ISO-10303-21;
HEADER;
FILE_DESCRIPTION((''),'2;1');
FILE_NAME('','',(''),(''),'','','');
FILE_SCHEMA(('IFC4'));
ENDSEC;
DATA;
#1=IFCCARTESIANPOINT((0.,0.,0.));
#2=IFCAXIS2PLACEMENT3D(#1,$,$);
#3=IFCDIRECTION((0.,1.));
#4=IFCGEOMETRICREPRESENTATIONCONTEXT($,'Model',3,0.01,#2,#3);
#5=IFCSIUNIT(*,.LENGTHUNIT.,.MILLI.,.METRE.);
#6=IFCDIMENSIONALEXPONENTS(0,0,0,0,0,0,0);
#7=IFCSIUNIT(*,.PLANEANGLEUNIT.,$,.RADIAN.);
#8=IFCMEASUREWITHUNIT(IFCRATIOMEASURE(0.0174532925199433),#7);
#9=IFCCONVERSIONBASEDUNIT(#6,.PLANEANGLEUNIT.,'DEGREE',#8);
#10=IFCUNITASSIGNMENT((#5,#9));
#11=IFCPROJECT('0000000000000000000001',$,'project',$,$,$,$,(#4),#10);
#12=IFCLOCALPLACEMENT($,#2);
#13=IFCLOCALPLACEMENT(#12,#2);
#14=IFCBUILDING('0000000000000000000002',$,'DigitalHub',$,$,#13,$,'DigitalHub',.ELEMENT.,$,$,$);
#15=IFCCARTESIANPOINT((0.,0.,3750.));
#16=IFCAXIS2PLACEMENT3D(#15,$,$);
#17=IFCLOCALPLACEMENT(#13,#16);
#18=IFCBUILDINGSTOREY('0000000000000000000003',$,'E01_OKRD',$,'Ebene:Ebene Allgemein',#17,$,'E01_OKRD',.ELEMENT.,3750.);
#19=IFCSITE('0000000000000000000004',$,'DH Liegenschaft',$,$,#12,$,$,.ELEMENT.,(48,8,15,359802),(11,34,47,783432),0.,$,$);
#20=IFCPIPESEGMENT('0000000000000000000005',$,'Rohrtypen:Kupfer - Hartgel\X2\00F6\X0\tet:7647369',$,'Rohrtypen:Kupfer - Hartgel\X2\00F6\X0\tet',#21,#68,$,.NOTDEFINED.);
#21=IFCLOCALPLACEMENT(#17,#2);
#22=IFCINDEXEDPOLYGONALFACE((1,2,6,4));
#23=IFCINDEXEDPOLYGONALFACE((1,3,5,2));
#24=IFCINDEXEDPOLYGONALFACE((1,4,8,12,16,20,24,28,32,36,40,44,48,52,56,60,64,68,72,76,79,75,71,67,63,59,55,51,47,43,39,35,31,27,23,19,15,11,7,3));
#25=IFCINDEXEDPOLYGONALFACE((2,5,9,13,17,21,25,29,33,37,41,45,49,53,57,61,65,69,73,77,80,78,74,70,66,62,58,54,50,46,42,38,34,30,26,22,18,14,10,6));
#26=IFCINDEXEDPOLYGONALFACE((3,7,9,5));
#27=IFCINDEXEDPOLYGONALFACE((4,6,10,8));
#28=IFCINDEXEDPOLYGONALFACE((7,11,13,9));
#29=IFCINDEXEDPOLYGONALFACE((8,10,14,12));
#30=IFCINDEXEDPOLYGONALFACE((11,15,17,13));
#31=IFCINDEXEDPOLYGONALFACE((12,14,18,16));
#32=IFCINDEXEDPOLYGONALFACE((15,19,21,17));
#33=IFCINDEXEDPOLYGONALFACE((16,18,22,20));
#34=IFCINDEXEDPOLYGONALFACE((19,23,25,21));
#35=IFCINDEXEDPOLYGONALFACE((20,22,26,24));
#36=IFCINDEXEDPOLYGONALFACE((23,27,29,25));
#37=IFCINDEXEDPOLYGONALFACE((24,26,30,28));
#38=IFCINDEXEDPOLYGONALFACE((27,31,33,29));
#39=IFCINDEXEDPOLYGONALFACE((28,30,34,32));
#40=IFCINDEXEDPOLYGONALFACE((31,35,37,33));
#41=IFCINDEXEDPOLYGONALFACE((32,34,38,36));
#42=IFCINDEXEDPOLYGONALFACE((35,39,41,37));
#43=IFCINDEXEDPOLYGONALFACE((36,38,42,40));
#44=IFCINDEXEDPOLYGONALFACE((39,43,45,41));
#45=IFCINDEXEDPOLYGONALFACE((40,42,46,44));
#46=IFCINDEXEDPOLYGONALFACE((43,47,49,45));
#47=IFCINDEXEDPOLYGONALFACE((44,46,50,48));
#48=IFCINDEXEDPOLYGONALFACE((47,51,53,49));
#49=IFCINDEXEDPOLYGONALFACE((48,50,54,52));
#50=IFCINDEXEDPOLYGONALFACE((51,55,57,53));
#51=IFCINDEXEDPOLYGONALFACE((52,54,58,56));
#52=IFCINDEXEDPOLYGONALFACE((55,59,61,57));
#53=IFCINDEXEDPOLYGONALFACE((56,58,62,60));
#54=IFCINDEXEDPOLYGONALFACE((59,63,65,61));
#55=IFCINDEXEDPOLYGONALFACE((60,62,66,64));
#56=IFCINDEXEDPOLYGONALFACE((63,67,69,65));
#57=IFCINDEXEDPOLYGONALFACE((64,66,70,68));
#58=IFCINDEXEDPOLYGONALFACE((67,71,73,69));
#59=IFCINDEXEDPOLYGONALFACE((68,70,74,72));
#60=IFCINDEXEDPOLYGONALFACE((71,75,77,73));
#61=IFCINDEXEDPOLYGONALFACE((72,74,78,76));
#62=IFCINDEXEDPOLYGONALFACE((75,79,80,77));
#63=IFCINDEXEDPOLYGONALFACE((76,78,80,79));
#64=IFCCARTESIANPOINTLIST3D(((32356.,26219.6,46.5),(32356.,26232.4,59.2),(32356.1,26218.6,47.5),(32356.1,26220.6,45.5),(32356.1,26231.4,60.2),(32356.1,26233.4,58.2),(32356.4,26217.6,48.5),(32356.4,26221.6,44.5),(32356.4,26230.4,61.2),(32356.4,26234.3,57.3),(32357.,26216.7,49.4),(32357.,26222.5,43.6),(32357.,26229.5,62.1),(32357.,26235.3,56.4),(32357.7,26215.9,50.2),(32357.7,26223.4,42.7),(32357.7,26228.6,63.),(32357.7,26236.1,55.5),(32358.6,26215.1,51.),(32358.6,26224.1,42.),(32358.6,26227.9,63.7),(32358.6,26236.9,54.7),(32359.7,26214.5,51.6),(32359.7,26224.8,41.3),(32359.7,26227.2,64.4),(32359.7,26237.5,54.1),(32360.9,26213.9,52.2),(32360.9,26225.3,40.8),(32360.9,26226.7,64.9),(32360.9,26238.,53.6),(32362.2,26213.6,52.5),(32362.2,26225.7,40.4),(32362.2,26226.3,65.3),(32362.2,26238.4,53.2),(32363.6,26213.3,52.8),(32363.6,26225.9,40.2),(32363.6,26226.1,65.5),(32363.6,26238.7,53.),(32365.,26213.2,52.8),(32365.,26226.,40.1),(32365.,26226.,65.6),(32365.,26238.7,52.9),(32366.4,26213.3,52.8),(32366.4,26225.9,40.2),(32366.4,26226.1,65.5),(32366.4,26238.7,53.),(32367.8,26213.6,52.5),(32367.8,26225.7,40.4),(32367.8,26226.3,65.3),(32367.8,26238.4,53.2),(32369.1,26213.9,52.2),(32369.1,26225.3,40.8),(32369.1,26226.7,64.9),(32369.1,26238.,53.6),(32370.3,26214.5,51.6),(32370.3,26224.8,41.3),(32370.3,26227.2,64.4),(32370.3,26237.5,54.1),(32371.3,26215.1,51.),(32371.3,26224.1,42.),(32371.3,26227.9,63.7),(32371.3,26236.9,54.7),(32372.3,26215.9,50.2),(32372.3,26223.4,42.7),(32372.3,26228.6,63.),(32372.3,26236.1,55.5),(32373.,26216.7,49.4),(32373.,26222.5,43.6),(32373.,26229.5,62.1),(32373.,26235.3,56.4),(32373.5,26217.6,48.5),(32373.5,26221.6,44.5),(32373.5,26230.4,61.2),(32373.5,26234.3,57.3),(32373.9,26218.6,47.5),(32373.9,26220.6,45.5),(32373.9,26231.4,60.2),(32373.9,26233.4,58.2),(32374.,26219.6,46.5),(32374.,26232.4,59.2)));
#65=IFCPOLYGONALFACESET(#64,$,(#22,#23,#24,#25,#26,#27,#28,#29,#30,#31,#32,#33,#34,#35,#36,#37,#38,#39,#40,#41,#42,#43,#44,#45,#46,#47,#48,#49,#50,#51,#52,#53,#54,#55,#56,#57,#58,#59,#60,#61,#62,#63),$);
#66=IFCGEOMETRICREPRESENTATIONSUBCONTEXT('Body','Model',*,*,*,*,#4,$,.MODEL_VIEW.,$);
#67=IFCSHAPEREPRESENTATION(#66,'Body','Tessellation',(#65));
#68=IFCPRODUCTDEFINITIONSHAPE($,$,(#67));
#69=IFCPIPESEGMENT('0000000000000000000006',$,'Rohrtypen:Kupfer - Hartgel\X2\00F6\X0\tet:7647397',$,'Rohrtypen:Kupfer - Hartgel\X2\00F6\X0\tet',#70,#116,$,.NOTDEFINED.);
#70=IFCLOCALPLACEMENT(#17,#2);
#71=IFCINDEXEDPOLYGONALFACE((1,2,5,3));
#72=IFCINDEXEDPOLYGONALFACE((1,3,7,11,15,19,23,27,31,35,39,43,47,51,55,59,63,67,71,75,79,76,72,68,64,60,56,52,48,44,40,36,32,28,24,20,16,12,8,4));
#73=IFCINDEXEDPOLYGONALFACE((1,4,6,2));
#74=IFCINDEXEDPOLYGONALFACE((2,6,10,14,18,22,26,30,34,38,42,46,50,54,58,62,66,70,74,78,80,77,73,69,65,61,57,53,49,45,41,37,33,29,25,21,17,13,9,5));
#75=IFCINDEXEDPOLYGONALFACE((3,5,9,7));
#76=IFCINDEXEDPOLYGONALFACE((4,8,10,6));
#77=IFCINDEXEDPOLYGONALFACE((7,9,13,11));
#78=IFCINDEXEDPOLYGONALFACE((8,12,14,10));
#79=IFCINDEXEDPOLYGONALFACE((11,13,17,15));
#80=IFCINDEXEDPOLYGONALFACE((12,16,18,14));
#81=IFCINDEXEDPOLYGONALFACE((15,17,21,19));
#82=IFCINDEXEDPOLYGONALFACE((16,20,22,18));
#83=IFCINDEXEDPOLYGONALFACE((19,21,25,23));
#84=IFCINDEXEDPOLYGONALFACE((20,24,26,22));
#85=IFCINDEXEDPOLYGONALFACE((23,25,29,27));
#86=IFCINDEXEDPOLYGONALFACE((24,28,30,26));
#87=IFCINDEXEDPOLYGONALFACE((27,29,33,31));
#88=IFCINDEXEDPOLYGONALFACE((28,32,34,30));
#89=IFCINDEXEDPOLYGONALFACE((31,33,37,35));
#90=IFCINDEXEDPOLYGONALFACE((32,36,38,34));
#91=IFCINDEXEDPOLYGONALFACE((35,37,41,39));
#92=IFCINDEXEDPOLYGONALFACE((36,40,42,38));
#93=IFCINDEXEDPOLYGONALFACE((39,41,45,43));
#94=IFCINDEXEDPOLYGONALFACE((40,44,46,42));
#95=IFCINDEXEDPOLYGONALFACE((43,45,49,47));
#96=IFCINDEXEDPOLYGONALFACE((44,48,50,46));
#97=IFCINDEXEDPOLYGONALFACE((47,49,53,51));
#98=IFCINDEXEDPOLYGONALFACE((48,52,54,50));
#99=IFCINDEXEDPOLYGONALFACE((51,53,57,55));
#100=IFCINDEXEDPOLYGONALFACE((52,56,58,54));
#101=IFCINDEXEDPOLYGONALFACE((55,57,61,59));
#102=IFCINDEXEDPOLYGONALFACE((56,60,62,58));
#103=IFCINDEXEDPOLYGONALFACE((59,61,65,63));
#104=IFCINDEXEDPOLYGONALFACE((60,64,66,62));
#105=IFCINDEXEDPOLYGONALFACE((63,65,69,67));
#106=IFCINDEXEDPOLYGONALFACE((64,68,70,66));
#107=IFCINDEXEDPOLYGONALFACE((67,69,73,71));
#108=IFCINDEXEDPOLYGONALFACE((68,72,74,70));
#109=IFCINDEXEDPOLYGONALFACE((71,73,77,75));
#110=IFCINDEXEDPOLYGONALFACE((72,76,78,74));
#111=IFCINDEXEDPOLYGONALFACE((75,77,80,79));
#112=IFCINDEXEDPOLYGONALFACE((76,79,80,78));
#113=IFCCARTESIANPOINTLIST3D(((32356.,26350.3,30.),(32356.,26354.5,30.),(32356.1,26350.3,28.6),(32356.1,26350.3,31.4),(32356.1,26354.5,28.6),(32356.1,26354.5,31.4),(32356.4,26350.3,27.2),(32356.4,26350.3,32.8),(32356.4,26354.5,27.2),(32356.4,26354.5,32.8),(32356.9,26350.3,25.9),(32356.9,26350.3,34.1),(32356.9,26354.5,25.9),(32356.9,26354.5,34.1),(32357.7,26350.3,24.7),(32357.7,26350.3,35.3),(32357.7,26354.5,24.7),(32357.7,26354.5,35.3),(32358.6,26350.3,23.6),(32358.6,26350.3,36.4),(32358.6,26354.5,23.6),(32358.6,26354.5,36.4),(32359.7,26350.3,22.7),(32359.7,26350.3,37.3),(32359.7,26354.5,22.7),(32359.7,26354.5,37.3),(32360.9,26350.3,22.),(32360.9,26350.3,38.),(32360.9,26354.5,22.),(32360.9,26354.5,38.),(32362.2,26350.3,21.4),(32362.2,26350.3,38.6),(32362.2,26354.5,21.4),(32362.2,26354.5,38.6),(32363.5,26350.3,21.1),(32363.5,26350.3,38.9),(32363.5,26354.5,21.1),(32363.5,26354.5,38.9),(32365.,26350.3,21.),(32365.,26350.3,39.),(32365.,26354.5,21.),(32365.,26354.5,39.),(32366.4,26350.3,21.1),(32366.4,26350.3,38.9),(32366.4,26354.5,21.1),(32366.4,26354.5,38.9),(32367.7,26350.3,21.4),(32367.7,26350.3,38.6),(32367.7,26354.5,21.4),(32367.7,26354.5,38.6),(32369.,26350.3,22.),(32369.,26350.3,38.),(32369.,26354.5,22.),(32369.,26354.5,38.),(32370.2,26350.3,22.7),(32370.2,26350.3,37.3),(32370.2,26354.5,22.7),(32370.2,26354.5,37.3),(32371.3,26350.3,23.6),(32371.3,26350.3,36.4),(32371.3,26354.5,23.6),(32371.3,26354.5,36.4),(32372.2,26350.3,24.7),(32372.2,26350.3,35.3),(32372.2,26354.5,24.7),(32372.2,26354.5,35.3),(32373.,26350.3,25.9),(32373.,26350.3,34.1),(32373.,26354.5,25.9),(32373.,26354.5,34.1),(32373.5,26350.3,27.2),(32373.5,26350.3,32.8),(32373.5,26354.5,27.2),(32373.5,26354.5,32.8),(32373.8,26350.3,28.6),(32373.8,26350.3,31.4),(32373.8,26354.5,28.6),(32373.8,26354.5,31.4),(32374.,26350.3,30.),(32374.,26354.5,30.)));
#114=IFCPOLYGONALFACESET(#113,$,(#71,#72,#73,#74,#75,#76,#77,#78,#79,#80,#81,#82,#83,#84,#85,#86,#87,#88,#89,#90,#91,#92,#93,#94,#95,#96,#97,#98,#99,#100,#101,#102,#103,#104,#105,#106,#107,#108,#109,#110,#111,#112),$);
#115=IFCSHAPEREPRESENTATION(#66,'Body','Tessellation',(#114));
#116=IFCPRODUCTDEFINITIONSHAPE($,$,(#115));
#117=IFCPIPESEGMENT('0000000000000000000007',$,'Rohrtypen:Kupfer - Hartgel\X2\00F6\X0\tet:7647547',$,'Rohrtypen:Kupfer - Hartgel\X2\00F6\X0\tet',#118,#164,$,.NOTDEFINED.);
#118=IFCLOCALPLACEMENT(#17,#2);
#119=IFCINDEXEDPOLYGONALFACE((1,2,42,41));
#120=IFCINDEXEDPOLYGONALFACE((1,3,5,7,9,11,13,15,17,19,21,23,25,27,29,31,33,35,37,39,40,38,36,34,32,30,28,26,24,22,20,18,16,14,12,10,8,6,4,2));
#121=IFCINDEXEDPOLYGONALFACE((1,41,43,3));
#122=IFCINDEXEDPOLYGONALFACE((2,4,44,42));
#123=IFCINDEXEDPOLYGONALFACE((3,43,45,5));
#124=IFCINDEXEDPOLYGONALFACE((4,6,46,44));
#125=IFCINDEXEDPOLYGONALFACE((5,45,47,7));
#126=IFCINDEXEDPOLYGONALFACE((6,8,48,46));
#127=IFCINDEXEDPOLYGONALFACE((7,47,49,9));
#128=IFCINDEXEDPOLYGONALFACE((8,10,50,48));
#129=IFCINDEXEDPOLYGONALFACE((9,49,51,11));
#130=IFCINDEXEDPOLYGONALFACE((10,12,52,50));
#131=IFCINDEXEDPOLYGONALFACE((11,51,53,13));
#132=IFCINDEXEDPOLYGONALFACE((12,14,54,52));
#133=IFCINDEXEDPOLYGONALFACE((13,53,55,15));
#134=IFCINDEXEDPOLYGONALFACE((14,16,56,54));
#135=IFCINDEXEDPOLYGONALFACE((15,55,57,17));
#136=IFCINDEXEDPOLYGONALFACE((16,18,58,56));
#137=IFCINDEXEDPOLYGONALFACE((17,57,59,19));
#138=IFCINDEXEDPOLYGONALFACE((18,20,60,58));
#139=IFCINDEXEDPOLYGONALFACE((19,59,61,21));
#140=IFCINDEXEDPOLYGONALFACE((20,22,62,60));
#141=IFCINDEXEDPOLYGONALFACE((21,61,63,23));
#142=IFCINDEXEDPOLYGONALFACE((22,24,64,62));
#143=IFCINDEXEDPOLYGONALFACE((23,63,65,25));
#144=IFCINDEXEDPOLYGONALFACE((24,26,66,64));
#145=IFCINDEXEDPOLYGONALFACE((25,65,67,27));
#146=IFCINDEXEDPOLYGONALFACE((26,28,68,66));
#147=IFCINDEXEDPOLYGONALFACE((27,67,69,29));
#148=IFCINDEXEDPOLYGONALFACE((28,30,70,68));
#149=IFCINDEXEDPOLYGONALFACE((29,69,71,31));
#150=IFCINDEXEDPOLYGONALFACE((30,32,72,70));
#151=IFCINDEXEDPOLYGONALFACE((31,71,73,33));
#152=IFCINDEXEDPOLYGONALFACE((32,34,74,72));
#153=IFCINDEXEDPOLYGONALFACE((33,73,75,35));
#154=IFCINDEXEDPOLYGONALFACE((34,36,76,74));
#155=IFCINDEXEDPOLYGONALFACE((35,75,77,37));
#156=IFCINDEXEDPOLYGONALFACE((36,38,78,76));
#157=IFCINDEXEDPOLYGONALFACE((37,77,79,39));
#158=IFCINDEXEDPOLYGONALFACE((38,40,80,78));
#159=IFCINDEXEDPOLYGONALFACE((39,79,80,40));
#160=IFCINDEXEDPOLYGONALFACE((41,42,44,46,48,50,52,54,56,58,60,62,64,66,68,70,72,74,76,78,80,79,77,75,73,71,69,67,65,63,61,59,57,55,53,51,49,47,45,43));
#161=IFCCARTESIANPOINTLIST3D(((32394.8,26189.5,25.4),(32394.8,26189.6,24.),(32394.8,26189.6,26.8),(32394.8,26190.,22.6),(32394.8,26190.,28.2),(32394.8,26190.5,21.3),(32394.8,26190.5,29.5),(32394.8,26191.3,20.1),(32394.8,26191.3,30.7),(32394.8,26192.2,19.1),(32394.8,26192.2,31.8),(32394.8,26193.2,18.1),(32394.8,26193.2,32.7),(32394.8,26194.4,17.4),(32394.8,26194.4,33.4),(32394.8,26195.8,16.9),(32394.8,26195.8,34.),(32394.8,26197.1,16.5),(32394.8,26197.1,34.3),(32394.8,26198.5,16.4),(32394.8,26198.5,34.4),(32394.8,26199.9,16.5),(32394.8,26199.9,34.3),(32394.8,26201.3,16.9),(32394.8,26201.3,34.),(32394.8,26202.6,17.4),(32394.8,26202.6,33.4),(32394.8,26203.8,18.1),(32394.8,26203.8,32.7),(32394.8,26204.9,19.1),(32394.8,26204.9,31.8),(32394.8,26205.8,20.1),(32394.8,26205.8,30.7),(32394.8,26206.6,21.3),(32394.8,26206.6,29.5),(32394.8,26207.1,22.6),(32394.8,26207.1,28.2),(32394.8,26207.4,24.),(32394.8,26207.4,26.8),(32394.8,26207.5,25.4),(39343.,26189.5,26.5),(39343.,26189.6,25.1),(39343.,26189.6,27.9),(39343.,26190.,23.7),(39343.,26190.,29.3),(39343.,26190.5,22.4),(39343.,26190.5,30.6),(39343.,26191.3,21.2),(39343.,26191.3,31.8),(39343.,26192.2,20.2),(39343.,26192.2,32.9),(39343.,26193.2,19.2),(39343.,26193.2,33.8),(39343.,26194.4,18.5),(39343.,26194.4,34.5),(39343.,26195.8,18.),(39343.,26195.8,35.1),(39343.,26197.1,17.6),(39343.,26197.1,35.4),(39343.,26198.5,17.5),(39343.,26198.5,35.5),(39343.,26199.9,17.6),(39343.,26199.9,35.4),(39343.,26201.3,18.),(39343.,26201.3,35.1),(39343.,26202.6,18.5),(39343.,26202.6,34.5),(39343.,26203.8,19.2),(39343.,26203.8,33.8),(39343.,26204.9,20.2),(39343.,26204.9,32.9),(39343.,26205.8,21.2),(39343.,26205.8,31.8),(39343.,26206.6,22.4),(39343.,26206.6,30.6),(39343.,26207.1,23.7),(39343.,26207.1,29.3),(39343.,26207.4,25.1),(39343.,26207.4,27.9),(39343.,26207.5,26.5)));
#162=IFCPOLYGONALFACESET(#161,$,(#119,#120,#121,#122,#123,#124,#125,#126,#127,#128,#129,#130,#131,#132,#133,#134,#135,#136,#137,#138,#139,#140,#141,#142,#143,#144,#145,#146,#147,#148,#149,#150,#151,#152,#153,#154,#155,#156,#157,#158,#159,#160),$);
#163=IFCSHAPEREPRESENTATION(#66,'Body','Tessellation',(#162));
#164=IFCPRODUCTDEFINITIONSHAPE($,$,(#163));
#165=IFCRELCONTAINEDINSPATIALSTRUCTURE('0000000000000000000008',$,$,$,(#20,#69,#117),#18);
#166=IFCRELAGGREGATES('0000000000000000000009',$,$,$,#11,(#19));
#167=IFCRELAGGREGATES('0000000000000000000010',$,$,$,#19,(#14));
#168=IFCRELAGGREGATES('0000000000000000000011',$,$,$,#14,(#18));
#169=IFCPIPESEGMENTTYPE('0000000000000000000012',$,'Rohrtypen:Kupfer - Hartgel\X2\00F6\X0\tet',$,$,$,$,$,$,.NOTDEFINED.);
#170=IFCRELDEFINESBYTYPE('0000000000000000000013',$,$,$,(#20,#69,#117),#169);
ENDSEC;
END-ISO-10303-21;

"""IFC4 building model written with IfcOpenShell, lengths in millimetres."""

from ifc_helpers import new_model, entity, si_unit, converted_unit, direction, frame, origin, place, context, subcontext, project, spatial, indexed_curve, outline, extrude, type_object, element, save


model = new_model("IFC4")

# Units and contexts
model_context = context("Model", 3, precision=0.01, world=origin(), true_north=direction((0.0, 1.0)))
body_context = subcontext(model_context, "Body", "Model", "MODEL_VIEW")
ifc_project = project(units=[si_unit("LENGTHUNIT", "METRE", prefix="MILLI"), converted_unit("PLANEANGLEUNIT", "DEGREE", entity("IfcRatioMeasure", 0.0174532925199433), si_unit("PLANEANGLEUNIT", "RADIAN"), dimensions=[0, 0, 0, 0, 0, 0, 0])], contexts=[model_context])

# Site, building, storey
site_placement = place(None, origin())
site = spatial("IfcSite", under=ifc_project, at=site_placement, Name="DH Liegenschaft", CompositionType="ELEMENT", RefLatitude=(48, 8, 15, 359802), RefLongitude=(11, 34, 47, 783432), RefElevation=0.0)
building_placement = place(site_placement, origin())
building = spatial("IfcBuilding", under=site, at=building_placement, Name="DigitalHub", LongName="DigitalHub", CompositionType="ELEMENT")
storey_placement = place(building_placement, frame((0.0, 0.0, 3750.0)))
storey = spatial("IfcBuildingStorey", under=building, at=storey_placement, Name="E01_OKRD", ObjectType="Ebene:Ebene Allgemein", LongName="E01_OKRD", CompositionType="ELEMENT", Elevation=3750.0)

# Pipe segments
pipe_segment_type = type_object("IfcPipeSegmentType", Name="Rohrtypen:Kupfer - Hartgelötet", PredefinedType="NOTDEFINED")
pipe_segment_1_placement = place(storey_placement, frame((32354.4, 26211.7, 38.5)))
element("IfcPipeSegment", 1, at=pipe_segment_1_placement, inside=storey, type_object=pipe_segment_type, Name="Rohrtypen:Kupfer - Hartgelötet:7647369", ObjectType="Rohrtypen:Kupfer - Hartgelötet", PredefinedType="NOTDEFINED", context=body_context, shape_type="SweptSolid", body=[
    extrude(outline(indexed_curve([(9.0, 0.0), (8.9, 1.4), (8.6, 2.8), (8.0, 4.1), (7.3, 5.3), (6.4, 6.4), (5.3, 7.3), (4.1, 8.0), (2.8, 8.6), (1.4, 8.9), (0.0, 9.0), (-1.4, 8.9), (-2.8, 8.6), (-4.1, 8.0), (-5.3, 7.3), (-6.4, 6.4), (-7.3, 5.3), (-8.0, 4.1), (-8.6, 2.8), (-8.9, 1.4), (-9.0, 0.0), (-8.9, -1.4), (-8.6, -2.8), (-8.0, -4.1), (-7.3, -5.3), (-6.4, -6.4), (-5.3, -7.3), (-4.1, -8.0), (-2.8, -8.6), (-1.4, -8.9), (0.0, -9.0), (1.4, -8.9), (2.8, -8.6), (4.1, -8.0), (5.3, -7.3), (6.4, -6.4), (7.3, -5.3), (8.0, -4.1), (8.6, -2.8), (8.9, -1.4), (9.0, 0.0)], self_intersect=False)), frame((10.6, 8.0, 8.0), z_axis=(0.0, 0.707107, 0.707107), x_axis=(-1.0, 0.0, 0.0)), (0.0, 0.0, 1.0), 18.0),
])
pipe_segment_2_placement = place(storey_placement, frame((32354.4, 26350.3, 19.4)))
element("IfcPipeSegment", 2, at=pipe_segment_2_placement, inside=storey, type_object=pipe_segment_type, Name="Rohrtypen:Kupfer - Hartgelötet:7647397", ObjectType="Rohrtypen:Kupfer - Hartgelötet", PredefinedType="NOTDEFINED", context=body_context, shape_type="SweptSolid", body=[
    extrude(outline(indexed_curve([(9.0, 0.0), (8.9, 1.4), (8.6, 2.8), (8.0, 4.1), (7.3, 5.3), (6.4, 6.4), (5.3, 7.3), (4.1, 8.0), (2.8, 8.6), (1.4, 8.9), (0.0, 9.0), (-1.4, 8.9), (-2.8, 8.6), (-4.1, 8.0), (-5.3, 7.3), (-6.4, 6.4), (-7.3, 5.3), (-8.0, 4.1), (-8.6, 2.8), (-8.9, 1.4), (-9.0, 0.0), (-8.9, -1.4), (-8.6, -2.8), (-8.0, -4.1), (-7.3, -5.3), (-6.4, -6.4), (-5.3, -7.3), (-4.1, -8.0), (-2.8, -8.6), (-1.4, -8.9), (0.0, -9.0), (1.4, -8.9), (2.8, -8.6), (4.1, -8.0), (5.3, -7.3), (6.4, -6.4), (7.3, -5.3), (8.0, -4.1), (8.6, -2.8), (8.9, -1.4), (9.0, 0.0)], self_intersect=False)), frame((10.6, 0.0, 10.6), z_axis=(0.0, 1.0, 0.0), x_axis=(1.0, 0.0, 0.0)), (0.0, 0.0, 1.0), 4.2),
])
pipe_segment_3_placement = place(storey_placement, frame((32394.8, 26187.9, 14.8)))
element("IfcPipeSegment", 3, at=pipe_segment_3_placement, inside=storey, type_object=pipe_segment_type, Name="Rohrtypen:Kupfer - Hartgelötet:7647547", ObjectType="Rohrtypen:Kupfer - Hartgelötet", PredefinedType="NOTDEFINED", context=body_context, shape_type="SweptSolid", body=[
    extrude(outline(indexed_curve([(9.0, 0.0), (8.9, 1.4), (8.6, 2.8), (8.0, 4.1), (7.3, 5.3), (6.4, 6.4), (5.3, 7.3), (4.1, 8.0), (2.8, 8.6), (1.4, 8.9), (0.0, 9.0), (-1.4, 8.9), (-2.8, 8.6), (-4.1, 8.0), (-5.3, 7.3), (-6.4, 6.4), (-7.3, 5.3), (-8.0, 4.1), (-8.6, 2.8), (-8.9, 1.4), (-9.0, 0.0), (-8.9, -1.4), (-8.6, -2.8), (-8.0, -4.1), (-7.3, -5.3), (-6.4, -6.4), (-5.3, -7.3), (-4.1, -8.0), (-2.8, -8.6), (-1.4, -8.9), (0.0, -9.0), (1.4, -8.9), (2.8, -8.6), (4.1, -8.0), (5.3, -7.3), (6.4, -6.4), (7.3, -5.3), (8.0, -4.1), (8.6, -2.8), (8.9, -1.4), (9.0, 0.0)], self_intersect=False)), frame((0.0, 10.6, 10.6), z_axis=(1.0, 0.0, 0.000158), x_axis=(0.0, -1.0, 0.0)), (0.0, 0.0, 1.0), 6948.2),
])

save(model, "model.ifc")
